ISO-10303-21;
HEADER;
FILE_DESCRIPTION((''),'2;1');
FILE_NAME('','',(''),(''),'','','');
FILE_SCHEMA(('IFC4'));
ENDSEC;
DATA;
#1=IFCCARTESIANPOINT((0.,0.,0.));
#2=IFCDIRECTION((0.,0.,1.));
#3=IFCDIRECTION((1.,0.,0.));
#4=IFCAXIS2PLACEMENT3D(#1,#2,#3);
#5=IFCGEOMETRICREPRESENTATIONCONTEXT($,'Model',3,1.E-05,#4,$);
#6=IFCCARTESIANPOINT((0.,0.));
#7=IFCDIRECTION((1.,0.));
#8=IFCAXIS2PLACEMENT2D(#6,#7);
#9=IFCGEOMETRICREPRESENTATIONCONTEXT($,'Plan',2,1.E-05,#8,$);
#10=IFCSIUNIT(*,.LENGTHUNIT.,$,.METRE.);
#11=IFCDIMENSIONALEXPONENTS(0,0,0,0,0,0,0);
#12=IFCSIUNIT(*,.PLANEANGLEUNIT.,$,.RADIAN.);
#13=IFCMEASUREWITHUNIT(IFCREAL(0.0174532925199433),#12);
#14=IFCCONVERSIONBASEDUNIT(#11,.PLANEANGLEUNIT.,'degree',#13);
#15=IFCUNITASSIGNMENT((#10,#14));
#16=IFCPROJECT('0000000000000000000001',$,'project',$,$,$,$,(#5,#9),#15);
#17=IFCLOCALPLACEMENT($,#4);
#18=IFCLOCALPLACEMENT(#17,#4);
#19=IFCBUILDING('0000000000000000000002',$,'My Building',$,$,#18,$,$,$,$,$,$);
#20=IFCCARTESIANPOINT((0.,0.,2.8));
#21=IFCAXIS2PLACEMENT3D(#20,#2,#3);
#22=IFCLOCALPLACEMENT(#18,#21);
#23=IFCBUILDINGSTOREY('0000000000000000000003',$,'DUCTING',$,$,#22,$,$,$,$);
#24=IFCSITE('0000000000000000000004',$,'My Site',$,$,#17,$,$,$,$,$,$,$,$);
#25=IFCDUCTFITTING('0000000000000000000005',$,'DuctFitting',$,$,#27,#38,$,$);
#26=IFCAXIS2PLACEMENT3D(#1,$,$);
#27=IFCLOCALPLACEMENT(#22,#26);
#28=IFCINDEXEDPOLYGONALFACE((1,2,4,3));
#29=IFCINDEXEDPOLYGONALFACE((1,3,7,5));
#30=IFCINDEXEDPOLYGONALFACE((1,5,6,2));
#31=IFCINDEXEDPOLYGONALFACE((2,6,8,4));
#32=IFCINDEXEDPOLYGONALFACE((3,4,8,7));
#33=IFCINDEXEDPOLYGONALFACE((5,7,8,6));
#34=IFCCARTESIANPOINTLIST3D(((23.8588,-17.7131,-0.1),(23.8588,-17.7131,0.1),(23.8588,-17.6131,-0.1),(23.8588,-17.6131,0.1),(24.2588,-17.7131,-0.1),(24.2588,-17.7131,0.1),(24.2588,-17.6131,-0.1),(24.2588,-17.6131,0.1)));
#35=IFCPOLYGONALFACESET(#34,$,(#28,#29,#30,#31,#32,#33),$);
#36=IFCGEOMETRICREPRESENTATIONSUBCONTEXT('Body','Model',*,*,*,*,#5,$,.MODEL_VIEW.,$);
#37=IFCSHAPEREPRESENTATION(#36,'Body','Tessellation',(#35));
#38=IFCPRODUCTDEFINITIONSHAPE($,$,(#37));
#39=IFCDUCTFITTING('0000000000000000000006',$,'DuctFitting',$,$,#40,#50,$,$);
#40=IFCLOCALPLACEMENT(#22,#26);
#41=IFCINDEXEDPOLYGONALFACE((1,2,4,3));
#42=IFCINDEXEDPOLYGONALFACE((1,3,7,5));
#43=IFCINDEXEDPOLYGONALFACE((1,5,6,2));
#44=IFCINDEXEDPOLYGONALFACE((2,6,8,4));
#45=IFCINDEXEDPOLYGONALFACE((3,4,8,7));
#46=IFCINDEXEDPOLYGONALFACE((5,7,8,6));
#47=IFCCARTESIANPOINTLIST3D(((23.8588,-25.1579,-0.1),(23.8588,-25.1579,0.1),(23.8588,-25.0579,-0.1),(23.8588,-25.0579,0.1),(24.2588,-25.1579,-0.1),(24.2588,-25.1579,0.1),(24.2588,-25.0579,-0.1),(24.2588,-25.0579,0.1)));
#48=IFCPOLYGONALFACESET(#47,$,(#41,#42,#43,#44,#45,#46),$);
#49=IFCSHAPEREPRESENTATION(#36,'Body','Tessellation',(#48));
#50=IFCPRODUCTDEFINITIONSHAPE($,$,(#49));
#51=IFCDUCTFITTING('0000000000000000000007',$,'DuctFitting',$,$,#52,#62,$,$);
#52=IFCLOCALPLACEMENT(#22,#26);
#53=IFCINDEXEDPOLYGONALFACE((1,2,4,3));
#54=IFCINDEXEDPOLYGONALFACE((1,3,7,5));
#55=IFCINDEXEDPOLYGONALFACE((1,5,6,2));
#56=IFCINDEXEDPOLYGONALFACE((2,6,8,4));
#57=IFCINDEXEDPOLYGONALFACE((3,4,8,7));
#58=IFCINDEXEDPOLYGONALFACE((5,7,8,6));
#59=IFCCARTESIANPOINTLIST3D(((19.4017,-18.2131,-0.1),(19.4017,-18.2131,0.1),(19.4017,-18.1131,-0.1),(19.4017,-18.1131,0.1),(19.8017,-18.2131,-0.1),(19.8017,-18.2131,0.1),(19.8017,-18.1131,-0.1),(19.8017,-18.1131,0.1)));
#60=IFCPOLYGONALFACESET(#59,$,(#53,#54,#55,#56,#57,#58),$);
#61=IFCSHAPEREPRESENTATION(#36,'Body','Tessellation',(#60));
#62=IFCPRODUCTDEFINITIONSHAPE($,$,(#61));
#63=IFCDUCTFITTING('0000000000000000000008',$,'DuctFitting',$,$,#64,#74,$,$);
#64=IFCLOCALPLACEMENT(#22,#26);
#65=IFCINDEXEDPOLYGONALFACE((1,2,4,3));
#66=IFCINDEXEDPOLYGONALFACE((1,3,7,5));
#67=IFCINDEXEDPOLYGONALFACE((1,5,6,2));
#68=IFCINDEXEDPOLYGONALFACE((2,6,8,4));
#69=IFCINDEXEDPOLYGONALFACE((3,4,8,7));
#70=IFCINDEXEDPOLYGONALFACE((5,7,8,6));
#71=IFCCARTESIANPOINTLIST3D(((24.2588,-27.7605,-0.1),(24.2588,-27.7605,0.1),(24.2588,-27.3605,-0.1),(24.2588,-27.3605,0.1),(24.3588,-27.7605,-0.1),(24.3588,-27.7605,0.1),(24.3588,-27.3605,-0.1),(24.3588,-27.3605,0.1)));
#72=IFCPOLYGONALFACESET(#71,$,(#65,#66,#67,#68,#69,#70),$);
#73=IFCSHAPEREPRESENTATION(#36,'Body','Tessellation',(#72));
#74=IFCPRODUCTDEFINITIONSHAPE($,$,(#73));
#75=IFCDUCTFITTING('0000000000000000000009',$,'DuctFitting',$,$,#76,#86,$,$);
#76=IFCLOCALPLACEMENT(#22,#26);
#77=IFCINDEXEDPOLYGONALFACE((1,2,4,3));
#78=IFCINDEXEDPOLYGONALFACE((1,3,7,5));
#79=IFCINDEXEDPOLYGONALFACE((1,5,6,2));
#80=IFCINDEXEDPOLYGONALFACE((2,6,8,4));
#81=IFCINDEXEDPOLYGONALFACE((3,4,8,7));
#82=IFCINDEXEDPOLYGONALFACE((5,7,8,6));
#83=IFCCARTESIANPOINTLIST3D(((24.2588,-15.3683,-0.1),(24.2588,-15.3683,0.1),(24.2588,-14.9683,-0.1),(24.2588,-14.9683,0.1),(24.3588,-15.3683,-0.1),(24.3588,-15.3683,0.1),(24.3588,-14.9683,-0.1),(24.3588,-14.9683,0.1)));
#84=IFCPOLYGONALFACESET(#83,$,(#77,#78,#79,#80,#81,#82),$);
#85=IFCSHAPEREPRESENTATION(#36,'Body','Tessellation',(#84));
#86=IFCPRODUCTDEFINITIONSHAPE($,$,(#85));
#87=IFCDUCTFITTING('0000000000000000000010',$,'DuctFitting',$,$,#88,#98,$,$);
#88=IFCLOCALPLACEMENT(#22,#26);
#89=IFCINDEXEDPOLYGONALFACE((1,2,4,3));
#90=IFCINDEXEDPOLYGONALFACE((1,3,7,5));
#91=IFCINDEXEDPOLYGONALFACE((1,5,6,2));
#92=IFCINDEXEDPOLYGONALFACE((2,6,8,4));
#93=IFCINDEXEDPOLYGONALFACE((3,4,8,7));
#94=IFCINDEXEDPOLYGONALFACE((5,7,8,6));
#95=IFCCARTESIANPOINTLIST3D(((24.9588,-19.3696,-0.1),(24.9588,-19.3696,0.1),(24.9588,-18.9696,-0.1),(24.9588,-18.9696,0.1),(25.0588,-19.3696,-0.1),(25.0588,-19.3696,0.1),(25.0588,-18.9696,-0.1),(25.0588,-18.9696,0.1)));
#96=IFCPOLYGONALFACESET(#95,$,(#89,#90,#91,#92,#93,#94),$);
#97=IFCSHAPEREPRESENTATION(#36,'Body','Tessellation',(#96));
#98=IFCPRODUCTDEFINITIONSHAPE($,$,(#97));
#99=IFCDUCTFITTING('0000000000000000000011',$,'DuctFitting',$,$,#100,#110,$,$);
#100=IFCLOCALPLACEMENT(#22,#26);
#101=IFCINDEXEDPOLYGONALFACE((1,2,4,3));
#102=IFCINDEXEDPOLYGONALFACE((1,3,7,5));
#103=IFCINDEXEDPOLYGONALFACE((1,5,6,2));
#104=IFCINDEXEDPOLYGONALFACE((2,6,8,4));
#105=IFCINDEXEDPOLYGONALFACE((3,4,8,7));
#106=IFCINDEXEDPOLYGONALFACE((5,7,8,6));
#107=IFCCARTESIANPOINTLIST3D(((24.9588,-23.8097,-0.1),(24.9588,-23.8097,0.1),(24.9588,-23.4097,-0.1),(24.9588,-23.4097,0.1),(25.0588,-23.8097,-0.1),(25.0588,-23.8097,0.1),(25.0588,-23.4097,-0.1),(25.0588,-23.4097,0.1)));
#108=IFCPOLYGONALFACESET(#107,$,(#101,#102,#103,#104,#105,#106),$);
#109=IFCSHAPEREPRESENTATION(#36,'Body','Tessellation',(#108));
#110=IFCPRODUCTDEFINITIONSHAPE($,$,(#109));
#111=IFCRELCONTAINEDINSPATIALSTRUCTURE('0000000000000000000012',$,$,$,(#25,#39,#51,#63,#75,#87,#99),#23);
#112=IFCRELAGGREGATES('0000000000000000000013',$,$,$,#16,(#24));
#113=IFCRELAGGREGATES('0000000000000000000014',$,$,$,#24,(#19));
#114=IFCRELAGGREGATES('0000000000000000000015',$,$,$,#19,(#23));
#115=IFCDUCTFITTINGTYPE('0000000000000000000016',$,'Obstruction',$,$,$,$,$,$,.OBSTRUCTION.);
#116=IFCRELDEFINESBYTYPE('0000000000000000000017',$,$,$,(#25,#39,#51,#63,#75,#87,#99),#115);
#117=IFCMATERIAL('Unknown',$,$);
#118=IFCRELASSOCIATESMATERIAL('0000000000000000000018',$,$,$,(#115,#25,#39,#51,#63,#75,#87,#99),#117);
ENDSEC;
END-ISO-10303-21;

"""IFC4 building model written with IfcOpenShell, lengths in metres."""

from ifc_helpers import new_model, entity, si_unit, converted_unit, frame, origin_with_axes, origin_2d_with_axis, place, context, subcontext, project, spatial, rectangle, extrude, material, material_profile, profile_set, profile_usage, type_object, element, save


model = new_model("IFC4")

# Units and contexts
model_context = context("Model", 3, precision=1e-05, world=origin_with_axes())
plan_context = context("Plan", 2, precision=1e-05, world=origin_2d_with_axis())
body_context = subcontext(model_context, "Body", "Model", "MODEL_VIEW")
ifc_project = project(units=[si_unit("LENGTHUNIT", "METRE"), converted_unit("PLANEANGLEUNIT", "degree", entity("IfcReal", 0.0174532925199433), si_unit("PLANEANGLEUNIT", "RADIAN"), dimensions=[0, 0, 0, 0, 0, 0, 0])], contexts=[model_context, plan_context])

# Site, building, storey
site_placement = place(None, origin_with_axes())
site = spatial("IfcSite", under=ifc_project, at=site_placement, Name="My Site")
building_placement = place(site_placement, origin_with_axes())
building = spatial("IfcBuilding", under=site, at=building_placement, Name="My Building")
storey_placement = place(building_placement, frame((0.0, 0.0, 2.8), z_axis=(0.0, 0.0, 1.0), x_axis=(1.0, 0.0, 0.0)))
storey = spatial("IfcBuildingStorey", under=building, at=storey_placement, Name="DUCTING")

# Shared definitions
ifc_material = material(Name="Unknown")

# Duct fittings
ifc_material_profile_1 = material_profile(ifc_material, rectangle(XDim=0.4, YDim=0.2))
ifc_profile_set_1 = profile_set([ifc_material_profile_1])
duct_fitting_type = type_object("IfcDuctFittingType", Name="Obstruction", PredefinedType="OBSTRUCTION", material=ifc_profile_set_1)
ifc_profile_usage_1 = profile_usage(ifc_profile_set_1, cardinal=5)
duct_fitting_1_placement = place(storey_placement, frame((24.0588, -17.7131, 0.0), z_axis=(0.0, 1.0, 0.0), x_axis=(-1.0, 0.0, 0.0)))
element("IfcDuctFitting", 1, at=duct_fitting_1_placement, inside=storey, type_object=duct_fitting_type, material=ifc_profile_usage_1, Name="DuctFitting", context=body_context, shape_type="SweptSolid", body=[
    extrude(rectangle(XDim=0.4, YDim=0.2), origin_with_axes(), (0.0, 0.0, 1.0), 0.1),
])
ifc_profile_usage_2 = profile_usage(ifc_profile_set_1, cardinal=5)
duct_fitting_2_placement = place(storey_placement, frame((24.0588, -25.0579, 0.0), z_axis=(0.0, -1.0, 0.0), x_axis=(-1.0, 0.0, 0.0)))
element("IfcDuctFitting", 2, at=duct_fitting_2_placement, inside=storey, type_object=duct_fitting_type, material=ifc_profile_usage_2, Name="DuctFitting", context=body_context, shape_type="SweptSolid", body=[
    extrude(rectangle(XDim=0.4, YDim=0.2), origin_with_axes(), (0.0, 0.0, 1.0), 0.1),
])
ifc_profile_usage_3 = profile_usage(ifc_profile_set_1, cardinal=5)
duct_fitting_3_placement = place(storey_placement, frame((19.6017, -18.2131, 0.0), z_axis=(0.0, 1.0, 0.0), x_axis=(-1.0, 0.0, 0.0)))
element("IfcDuctFitting", 3, at=duct_fitting_3_placement, inside=storey, type_object=duct_fitting_type, material=ifc_profile_usage_3, Name="DuctFitting", context=body_context, shape_type="SweptSolid", body=[
    extrude(rectangle(XDim=0.4, YDim=0.2), origin_with_axes(), (0.0, 0.0, 1.0), 0.1),
])
ifc_profile_usage_4 = profile_usage(ifc_profile_set_1, cardinal=5)
duct_fitting_4_placement = place(storey_placement, frame((24.3588, -27.5605, 0.0), z_axis=(-1.0, 0.0, 0.0), x_axis=(0.0, -1.0, 0.0)))
element("IfcDuctFitting", 4, at=duct_fitting_4_placement, inside=storey, type_object=duct_fitting_type, material=ifc_profile_usage_4, Name="DuctFitting", context=body_context, shape_type="SweptSolid", body=[
    extrude(rectangle(XDim=0.4, YDim=0.2), origin_with_axes(), (0.0, 0.0, 1.0), 0.1),
])
ifc_profile_usage_5 = profile_usage(ifc_profile_set_1, cardinal=5)
duct_fitting_5_placement = place(storey_placement, frame((24.3588, -15.1683, 0.0), z_axis=(-1.0, 0.0, 0.0), x_axis=(0.0, -1.0, 0.0)))
element("IfcDuctFitting", 5, at=duct_fitting_5_placement, inside=storey, type_object=duct_fitting_type, material=ifc_profile_usage_5, Name="DuctFitting", context=body_context, shape_type="SweptSolid", body=[
    extrude(rectangle(XDim=0.4, YDim=0.2), origin_with_axes(), (0.0, 0.0, 1.0), 0.1),
])
ifc_profile_usage_6 = profile_usage(ifc_profile_set_1, cardinal=5)
duct_fitting_6_placement = place(storey_placement, frame((25.0588, -19.1696, 0.0), z_axis=(-1.0, 0.0, 0.0), x_axis=(0.0, -1.0, 0.0)))
element("IfcDuctFitting", 6, at=duct_fitting_6_placement, inside=storey, type_object=duct_fitting_type, material=ifc_profile_usage_6, Name="DuctFitting", context=body_context, shape_type="SweptSolid", body=[
    extrude(rectangle(XDim=0.4, YDim=0.2), origin_with_axes(), (0.0, 0.0, 1.0), 0.1),
])
ifc_profile_usage_7 = profile_usage(ifc_profile_set_1, cardinal=5)
duct_fitting_7_placement = place(storey_placement, frame((25.0588, -23.6097, 0.0), z_axis=(-1.0, 0.0, 0.0), x_axis=(0.0, -1.0, 0.0)))
element("IfcDuctFitting", 7, at=duct_fitting_7_placement, inside=storey, type_object=duct_fitting_type, material=ifc_profile_usage_7, Name="DuctFitting", context=body_context, shape_type="SweptSolid", body=[
    extrude(rectangle(XDim=0.4, YDim=0.2), origin_with_axes(), (0.0, 0.0, 1.0), 0.1),
])

save(model, "model.ifc")
